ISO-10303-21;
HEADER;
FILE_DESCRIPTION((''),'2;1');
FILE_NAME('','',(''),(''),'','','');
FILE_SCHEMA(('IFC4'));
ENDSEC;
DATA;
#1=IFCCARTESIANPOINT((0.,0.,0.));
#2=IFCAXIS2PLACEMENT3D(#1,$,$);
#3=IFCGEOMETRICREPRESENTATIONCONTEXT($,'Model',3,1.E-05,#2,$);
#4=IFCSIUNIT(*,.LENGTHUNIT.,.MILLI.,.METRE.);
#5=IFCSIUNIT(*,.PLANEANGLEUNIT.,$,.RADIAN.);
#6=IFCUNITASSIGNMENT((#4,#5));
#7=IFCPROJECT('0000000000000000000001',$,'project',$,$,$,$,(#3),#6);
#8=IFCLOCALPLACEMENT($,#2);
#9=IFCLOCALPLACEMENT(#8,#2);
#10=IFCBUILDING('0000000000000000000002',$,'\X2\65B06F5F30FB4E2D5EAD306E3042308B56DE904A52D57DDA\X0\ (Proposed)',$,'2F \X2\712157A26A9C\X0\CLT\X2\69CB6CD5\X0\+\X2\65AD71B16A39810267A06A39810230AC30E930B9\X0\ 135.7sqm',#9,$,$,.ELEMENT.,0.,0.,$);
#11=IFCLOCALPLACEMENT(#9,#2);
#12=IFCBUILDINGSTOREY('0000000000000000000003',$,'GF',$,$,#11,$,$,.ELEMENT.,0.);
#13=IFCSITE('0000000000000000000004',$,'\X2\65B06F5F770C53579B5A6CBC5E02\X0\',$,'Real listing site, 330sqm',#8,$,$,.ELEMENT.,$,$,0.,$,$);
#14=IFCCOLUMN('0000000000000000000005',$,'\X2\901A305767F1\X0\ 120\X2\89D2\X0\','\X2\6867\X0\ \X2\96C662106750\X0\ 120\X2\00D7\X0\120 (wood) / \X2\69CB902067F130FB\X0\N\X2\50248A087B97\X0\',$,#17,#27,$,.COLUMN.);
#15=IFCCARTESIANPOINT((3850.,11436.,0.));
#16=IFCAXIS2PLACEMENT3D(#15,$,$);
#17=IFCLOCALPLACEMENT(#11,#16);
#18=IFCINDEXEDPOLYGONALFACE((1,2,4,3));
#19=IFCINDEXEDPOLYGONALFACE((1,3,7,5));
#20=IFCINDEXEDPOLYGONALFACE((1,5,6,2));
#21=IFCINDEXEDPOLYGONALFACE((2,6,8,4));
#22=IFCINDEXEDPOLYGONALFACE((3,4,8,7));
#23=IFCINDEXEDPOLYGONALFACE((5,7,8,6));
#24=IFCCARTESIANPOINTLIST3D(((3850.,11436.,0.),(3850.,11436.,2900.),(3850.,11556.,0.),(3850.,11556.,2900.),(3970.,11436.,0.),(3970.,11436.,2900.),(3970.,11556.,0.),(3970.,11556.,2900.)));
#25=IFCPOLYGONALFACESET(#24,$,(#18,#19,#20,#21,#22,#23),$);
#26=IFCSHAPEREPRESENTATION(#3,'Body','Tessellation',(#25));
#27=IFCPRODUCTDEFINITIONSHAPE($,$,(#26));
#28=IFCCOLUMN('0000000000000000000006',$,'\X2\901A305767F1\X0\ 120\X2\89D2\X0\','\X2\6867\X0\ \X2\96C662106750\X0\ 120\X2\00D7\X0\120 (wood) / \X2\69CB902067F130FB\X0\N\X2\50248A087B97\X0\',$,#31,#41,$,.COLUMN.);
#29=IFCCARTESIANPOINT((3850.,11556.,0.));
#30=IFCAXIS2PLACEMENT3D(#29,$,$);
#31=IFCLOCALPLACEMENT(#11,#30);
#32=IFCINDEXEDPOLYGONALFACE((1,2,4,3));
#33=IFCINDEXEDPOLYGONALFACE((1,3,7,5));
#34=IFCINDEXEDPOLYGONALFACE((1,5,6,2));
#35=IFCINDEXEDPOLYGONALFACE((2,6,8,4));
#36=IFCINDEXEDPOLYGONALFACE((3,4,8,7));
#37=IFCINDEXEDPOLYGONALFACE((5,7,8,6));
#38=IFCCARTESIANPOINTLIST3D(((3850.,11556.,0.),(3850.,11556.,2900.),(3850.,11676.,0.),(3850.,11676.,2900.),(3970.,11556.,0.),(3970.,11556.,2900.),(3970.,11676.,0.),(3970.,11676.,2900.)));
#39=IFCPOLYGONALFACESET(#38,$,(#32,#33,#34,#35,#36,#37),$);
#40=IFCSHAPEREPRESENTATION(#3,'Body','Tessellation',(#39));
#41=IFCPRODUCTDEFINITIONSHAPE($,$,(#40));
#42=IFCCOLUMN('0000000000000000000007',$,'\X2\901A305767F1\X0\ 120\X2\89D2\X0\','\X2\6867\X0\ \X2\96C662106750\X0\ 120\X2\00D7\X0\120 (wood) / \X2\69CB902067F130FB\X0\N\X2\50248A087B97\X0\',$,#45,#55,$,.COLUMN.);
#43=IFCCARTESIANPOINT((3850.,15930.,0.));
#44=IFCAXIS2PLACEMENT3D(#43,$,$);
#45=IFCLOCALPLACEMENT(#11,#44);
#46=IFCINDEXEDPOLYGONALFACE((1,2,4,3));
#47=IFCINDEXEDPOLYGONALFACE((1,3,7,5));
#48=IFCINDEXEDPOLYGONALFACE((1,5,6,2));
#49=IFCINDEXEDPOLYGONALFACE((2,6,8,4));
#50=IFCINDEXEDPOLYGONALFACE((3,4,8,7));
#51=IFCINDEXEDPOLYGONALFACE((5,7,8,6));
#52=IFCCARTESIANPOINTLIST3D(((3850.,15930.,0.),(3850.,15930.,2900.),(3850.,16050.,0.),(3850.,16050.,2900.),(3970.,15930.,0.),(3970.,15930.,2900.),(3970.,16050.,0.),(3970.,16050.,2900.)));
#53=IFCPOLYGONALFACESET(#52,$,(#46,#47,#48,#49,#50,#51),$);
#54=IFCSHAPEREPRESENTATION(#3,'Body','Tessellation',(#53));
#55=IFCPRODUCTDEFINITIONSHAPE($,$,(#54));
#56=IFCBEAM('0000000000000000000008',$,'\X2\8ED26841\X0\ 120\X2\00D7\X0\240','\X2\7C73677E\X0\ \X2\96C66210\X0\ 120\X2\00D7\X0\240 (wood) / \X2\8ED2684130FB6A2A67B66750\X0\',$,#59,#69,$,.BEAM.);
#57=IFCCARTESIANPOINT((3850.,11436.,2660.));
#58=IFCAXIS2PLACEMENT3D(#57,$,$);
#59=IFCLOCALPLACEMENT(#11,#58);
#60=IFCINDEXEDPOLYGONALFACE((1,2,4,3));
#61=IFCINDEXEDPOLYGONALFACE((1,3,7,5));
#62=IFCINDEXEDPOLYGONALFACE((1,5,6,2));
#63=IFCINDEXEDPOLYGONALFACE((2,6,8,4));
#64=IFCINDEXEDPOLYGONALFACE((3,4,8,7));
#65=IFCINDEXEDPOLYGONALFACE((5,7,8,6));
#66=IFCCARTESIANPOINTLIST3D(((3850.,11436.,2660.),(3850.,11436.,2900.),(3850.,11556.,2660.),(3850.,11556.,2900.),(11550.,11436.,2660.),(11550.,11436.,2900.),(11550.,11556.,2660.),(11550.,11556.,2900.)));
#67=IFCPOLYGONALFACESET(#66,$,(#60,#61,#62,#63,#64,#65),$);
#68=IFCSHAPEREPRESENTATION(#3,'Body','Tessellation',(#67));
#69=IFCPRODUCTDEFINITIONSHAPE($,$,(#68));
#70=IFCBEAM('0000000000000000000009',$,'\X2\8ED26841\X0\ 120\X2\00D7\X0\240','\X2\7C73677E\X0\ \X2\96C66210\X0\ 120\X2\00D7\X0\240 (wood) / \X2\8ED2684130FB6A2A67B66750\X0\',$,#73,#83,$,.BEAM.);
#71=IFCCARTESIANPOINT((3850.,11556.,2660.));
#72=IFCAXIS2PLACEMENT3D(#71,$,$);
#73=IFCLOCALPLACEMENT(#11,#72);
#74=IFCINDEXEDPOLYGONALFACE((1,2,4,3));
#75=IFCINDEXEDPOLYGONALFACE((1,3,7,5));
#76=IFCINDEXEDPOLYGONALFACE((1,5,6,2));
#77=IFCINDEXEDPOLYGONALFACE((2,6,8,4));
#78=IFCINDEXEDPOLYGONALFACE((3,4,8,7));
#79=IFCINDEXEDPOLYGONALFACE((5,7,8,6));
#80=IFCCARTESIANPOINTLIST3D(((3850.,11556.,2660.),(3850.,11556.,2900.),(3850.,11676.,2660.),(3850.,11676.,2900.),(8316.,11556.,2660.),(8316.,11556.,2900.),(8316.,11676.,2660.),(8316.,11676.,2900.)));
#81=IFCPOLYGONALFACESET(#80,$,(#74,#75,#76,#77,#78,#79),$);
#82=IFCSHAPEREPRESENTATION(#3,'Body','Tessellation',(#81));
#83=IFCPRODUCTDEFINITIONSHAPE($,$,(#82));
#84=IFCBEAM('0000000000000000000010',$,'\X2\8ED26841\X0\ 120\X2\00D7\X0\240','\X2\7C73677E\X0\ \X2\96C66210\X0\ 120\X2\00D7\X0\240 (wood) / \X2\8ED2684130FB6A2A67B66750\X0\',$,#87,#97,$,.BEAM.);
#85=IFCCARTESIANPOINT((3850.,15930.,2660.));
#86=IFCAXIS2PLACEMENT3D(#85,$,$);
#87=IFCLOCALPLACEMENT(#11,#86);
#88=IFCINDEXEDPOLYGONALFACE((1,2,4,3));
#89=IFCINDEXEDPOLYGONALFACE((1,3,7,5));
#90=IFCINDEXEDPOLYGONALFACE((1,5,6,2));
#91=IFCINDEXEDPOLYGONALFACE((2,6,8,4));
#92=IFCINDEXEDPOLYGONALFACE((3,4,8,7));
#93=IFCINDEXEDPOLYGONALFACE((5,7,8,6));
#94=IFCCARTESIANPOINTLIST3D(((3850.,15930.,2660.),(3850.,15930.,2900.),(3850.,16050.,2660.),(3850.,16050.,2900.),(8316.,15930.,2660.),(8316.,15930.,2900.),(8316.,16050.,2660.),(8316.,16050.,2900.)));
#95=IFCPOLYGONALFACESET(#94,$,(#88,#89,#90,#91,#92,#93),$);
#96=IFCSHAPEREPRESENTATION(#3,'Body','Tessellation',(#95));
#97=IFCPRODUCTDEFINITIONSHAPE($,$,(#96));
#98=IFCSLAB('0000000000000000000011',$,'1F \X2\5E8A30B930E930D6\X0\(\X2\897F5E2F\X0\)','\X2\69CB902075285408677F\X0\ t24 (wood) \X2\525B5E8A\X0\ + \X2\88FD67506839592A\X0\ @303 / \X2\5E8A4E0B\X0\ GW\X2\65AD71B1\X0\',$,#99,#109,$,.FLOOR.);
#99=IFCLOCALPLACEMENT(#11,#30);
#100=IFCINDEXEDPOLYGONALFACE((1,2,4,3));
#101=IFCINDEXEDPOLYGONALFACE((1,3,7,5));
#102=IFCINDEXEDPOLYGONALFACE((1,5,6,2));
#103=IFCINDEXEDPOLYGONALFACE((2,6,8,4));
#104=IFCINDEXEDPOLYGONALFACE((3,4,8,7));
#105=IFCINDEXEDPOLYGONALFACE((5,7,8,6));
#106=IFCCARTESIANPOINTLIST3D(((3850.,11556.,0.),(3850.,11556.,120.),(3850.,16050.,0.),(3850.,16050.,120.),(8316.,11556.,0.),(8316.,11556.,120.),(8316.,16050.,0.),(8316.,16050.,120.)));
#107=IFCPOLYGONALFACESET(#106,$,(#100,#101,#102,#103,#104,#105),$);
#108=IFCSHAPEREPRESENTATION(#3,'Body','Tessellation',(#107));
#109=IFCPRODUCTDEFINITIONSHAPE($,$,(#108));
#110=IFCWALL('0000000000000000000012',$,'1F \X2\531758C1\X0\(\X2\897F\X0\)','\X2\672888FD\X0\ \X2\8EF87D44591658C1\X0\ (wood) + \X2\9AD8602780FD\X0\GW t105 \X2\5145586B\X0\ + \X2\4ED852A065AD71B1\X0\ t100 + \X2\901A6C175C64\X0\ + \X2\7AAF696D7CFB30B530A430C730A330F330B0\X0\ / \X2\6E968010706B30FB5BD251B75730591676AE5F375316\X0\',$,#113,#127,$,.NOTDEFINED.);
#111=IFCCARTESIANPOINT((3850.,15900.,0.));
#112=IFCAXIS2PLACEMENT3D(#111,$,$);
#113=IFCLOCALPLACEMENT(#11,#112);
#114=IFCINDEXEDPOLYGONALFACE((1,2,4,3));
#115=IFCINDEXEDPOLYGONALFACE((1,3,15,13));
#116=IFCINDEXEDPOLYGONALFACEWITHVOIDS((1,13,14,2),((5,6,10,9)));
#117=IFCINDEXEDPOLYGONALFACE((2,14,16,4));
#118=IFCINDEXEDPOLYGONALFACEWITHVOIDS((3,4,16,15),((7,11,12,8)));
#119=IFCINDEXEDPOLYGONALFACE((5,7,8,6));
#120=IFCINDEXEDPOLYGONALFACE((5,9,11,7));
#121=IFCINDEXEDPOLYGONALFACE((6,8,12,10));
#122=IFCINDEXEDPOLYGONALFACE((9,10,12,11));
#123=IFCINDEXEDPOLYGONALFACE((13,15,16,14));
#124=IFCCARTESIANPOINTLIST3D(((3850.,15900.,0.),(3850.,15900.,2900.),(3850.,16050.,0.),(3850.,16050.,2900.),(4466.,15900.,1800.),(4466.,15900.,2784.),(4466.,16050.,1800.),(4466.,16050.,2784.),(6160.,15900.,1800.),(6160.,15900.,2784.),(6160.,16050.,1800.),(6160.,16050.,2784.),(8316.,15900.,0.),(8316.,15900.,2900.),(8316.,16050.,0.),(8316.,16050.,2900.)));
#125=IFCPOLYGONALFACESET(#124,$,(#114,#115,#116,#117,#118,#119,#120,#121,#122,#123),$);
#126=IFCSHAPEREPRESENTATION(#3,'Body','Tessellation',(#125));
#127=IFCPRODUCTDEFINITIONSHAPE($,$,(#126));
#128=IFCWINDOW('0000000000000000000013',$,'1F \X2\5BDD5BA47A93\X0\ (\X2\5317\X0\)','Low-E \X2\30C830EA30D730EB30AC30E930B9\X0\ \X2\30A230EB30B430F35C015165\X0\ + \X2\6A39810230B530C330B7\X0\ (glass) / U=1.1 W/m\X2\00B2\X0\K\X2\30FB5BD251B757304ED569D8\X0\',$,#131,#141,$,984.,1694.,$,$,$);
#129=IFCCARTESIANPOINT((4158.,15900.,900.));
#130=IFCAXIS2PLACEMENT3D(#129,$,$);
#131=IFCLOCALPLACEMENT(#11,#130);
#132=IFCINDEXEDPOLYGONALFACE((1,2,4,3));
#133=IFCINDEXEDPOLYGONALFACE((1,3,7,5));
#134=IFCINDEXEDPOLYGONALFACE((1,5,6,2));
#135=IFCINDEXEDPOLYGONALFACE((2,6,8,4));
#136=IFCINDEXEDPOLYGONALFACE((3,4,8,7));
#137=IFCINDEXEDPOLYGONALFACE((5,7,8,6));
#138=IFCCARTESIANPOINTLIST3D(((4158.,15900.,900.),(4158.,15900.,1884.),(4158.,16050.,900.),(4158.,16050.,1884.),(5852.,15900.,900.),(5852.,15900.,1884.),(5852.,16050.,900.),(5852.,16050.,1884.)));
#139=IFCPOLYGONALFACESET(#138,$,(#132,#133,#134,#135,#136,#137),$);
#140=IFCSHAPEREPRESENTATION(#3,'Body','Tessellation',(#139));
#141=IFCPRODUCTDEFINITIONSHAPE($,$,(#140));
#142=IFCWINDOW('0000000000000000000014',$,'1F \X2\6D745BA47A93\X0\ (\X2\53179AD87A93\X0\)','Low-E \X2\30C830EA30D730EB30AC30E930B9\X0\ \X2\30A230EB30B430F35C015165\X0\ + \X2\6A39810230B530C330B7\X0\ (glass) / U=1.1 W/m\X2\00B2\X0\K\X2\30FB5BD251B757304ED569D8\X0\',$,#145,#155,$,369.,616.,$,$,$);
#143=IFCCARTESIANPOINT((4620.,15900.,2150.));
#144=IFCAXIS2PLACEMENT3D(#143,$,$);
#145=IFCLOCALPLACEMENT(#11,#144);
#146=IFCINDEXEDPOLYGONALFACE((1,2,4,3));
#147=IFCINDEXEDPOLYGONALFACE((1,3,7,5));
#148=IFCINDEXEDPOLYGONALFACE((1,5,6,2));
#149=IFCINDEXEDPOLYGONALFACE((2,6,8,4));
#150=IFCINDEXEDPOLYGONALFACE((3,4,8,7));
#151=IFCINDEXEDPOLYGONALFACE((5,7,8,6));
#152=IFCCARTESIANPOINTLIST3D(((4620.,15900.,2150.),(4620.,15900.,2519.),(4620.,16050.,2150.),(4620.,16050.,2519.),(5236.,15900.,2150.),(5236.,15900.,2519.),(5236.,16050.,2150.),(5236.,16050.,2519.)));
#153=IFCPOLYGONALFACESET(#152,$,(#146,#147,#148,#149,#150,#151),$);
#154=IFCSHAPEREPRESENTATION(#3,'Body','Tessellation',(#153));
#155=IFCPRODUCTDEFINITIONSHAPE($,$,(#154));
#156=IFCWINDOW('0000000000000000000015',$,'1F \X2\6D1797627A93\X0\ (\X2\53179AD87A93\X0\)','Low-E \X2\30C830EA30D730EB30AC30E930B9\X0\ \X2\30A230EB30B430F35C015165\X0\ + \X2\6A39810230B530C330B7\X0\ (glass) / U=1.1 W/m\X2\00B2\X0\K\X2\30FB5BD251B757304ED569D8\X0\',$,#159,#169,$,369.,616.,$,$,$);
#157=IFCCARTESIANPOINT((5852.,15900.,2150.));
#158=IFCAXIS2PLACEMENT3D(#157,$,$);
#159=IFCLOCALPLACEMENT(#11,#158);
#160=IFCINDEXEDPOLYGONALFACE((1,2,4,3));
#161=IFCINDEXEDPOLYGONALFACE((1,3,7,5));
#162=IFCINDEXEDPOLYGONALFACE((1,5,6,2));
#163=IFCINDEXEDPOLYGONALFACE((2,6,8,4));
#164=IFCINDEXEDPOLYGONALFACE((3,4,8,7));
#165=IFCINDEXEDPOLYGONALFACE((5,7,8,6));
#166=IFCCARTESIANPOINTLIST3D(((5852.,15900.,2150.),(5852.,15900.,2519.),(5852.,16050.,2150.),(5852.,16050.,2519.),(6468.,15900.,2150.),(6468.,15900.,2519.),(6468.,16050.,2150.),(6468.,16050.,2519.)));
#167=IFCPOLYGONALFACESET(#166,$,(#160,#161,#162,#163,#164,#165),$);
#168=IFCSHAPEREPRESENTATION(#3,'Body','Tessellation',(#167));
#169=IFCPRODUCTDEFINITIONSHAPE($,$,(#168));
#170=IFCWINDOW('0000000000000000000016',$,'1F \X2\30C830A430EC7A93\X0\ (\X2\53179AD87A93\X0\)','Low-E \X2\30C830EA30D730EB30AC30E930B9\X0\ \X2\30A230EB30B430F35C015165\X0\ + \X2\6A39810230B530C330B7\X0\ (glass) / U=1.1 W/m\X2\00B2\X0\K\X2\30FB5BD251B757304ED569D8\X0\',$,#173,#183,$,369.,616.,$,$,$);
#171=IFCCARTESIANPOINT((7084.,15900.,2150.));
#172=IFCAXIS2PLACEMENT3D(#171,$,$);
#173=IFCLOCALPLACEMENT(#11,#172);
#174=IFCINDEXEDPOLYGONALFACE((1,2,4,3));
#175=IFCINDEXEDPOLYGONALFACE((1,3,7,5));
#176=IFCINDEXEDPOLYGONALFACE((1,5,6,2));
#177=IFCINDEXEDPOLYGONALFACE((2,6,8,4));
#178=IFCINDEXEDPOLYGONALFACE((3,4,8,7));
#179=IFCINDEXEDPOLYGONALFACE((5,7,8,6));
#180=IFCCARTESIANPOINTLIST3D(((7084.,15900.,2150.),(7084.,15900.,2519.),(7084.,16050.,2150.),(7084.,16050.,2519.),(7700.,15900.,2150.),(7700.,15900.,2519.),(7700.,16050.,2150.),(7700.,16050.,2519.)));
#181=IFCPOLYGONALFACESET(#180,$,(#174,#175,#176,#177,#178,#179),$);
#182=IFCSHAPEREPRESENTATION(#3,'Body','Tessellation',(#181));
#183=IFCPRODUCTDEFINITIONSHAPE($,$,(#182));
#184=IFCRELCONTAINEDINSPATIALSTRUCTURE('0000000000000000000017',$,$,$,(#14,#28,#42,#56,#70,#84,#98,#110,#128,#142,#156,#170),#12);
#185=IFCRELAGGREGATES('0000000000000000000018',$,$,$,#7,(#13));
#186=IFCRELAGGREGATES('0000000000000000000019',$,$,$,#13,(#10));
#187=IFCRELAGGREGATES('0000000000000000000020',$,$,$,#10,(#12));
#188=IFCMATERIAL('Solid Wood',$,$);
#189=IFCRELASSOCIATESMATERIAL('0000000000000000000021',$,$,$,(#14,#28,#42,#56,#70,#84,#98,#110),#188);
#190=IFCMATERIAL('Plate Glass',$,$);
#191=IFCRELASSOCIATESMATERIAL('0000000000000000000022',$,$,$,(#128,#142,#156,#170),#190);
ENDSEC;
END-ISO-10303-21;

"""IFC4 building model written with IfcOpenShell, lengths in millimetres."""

from ifc_helpers import new_model, si_unit, frame, frame_2d, origin, place, context, project, spatial, rectangle, extrude, material, element, fill, save


model = new_model("IFC4")

# Units and contexts
model_context = context("Model", 3, precision=1e-05, world=origin())
ifc_project = project(units=[si_unit("LENGTHUNIT", "METRE", prefix="MILLI"), si_unit("PLANEANGLEUNIT", "RADIAN")], contexts=[model_context])

# Site, building, storey
site_placement = place(None, origin())
site = spatial("IfcSite", under=ifc_project, at=site_placement, Name="新潟県南魚沼市", ObjectType="Real listing site, 330sqm", CompositionType="ELEMENT", RefElevation=0.0)
building_placement = place(site_placement, origin())
building = spatial("IfcBuilding", under=site, at=building_placement, Name="新潟・中庭のある回遊動線 (Proposed)", ObjectType="2F 無垢檜CLT構法+断熱樹脂枠樹脂ガラス 135.7sqm", CompositionType="ELEMENT", ElevationOfRefHeight=0.0, ElevationOfTerrain=0.0)
storey_placement = place(building_placement, origin())
storey = spatial("IfcBuildingStorey", under=building, at=storey_placement, Name="GF", CompositionType="ELEMENT", Elevation=0.0)

# Columns
ifc_material_1 = material(Name="Solid Wood")
column_1_placement = place(storey_placement, frame((3850.0, 11436.0, 0.0)))
element("IfcColumn", 1, at=column_1_placement, inside=storey, material=ifc_material_1, Name="通し柱 120角", Description="桧 集成材 120×120 (wood) / 構造柱・N値計算", PredefinedType="COLUMN", context=model_context, shape_type="SweptSolid", body=[
    extrude(rectangle(XDim=120.0, YDim=120.0, at=frame_2d((60.0, 60.0))), frame((3850.0, 11436.0, 0.0)), (0.0, 0.0, 1.0), 2900.0),
])
column_2_placement = place(storey_placement, frame((3850.0, 11556.0, 0.0)))
element("IfcColumn", 2, at=column_2_placement, inside=storey, material=ifc_material_1, Name="通し柱 120角", Description="桧 集成材 120×120 (wood) / 構造柱・N値計算", PredefinedType="COLUMN", context=model_context, shape_type="SweptSolid", body=[
    extrude(rectangle(XDim=120.0, YDim=120.0, at=frame_2d((60.0, 60.0))), frame((3850.0, 11556.0, 0.0)), (0.0, 0.0, 1.0), 2900.0),
])
column_3_placement = place(storey_placement, frame((3850.0, 15930.0, 0.0)))
element("IfcColumn", 3, at=column_3_placement, inside=storey, material=ifc_material_1, Name="通し柱 120角", Description="桧 集成材 120×120 (wood) / 構造柱・N値計算", PredefinedType="COLUMN", context=model_context, shape_type="SweptSolid", body=[
    extrude(rectangle(XDim=120.0, YDim=120.0, at=frame_2d((60.0, 60.0))), frame((3850.0, 15930.0, 0.0)), (0.0, 0.0, 1.0), 2900.0),
])

# Beams
beam_1_placement = place(storey_placement, frame((3850.0, 11436.0, 2660.0)))
element("IfcBeam", 4, at=beam_1_placement, inside=storey, material=ifc_material_1, Name="軒桁 120×240", Description="米松 集成 120×240 (wood) / 軒桁・横架材", PredefinedType="BEAM", context=model_context, shape_type="SweptSolid", body=[
    extrude(rectangle(XDim=7700.0, YDim=120.0, at=frame_2d((3850.0, 60.0))), frame((3850.0, 11436.0, 2660.0)), (0.0, 0.0, 1.0), 240.0),
])
beam_2_placement = place(storey_placement, frame((3850.0, 11556.0, 2660.0)))
element("IfcBeam", 5, at=beam_2_placement, inside=storey, material=ifc_material_1, Name="軒桁 120×240", Description="米松 集成 120×240 (wood) / 軒桁・横架材", PredefinedType="BEAM", context=model_context, shape_type="SweptSolid", body=[
    extrude(rectangle(XDim=4466.0, YDim=120.0, at=frame_2d((2233.0, 60.0))), frame((3850.0, 11556.0, 2660.0)), (0.0, 0.0, 1.0), 240.0),
])
beam_3_placement = place(storey_placement, frame((3850.0, 15930.0, 2660.0)))
element("IfcBeam", 6, at=beam_3_placement, inside=storey, material=ifc_material_1, Name="軒桁 120×240", Description="米松 集成 120×240 (wood) / 軒桁・横架材", PredefinedType="BEAM", context=model_context, shape_type="SweptSolid", body=[
    extrude(rectangle(XDim=4466.0, YDim=120.0, at=frame_2d((2233.0, 60.0))), frame((3850.0, 15930.0, 2660.0)), (0.0, 0.0, 1.0), 240.0),
])

# Slab
slab_placement = place(storey_placement, frame((3850.0, 11556.0, 0.0)))
element("IfcSlab", 7, at=slab_placement, inside=storey, material=ifc_material_1, Name="1F 床スラブ(西帯)", Description="構造用合板 t24 (wood) 剛床 + 製材根太 @303 / 床下 GW断熱", PredefinedType="FLOOR", context=model_context, shape_type="SweptSolid", body=[
    extrude(rectangle(XDim=4466.0, YDim=4494.0, at=frame_2d((2233.0, 2247.0))), frame((3850.0, 11556.0, 0.0)), (0.0, 0.0, 1.0), 120.0),
])

# Wall, openings, windows
wall_1_placement = place(storey_placement, frame((3850.0, 15900.0, 0.0)))
wall_1 = element("IfcWall", 8, at=wall_1_placement, inside=storey, material=ifc_material_1, Name="1F 北壁(西)", Description="木製 軸組外壁 (wood) + 高性能GW t105 充填 + 付加断熱 t100 + 通気層 + 窯業系サイディング / 準耐火・寒冷地外皮強化", PredefinedType="NOTDEFINED", context=model_context, shape_type="SweptSolid", body=[
    extrude(rectangle(XDim=4466.0, YDim=150.0, at=frame_2d((2233.0, 75.0))), frame((3850.0, 15900.0, 0.0)), (0.0, 0.0, 1.0), 2900.0),
])
opening_1_placement = place(storey_placement, frame((4158.0, 15900.0, 900.0)))
opening_1 = element("IfcOpeningElement", 9, at=opening_1_placement, cuts=wall_1, PredefinedType="NOTDEFINED", context=model_context, shape_type="SweptSolid", body=[
    extrude(rectangle(XDim=1694.0, YDim=150.0, at=frame_2d((847.0, 75.0))), frame((4158.0, 15900.0, 900.0)), (0.0, 0.0, 1.0), 984.0),
])
opening_2_placement = place(storey_placement, frame((4620.0, 15900.0, 2150.0)))
opening_2 = element("IfcOpeningElement", 10, at=opening_2_placement, cuts=wall_1, PredefinedType="NOTDEFINED", context=model_context, shape_type="SweptSolid", body=[
    extrude(rectangle(XDim=616.0, YDim=150.0, at=frame_2d((308.0, 75.0))), frame((4620.0, 15900.0, 2150.0)), (0.0, 0.0, 1.0), 369.0),
])
opening_3_placement = place(storey_placement, frame((5852.0, 15900.0, 2150.0)))
opening_3 = element("IfcOpeningElement", 11, at=opening_3_placement, cuts=wall_1, PredefinedType="NOTDEFINED", context=model_context, shape_type="SweptSolid", body=[
    extrude(rectangle(XDim=616.0, YDim=150.0, at=frame_2d((308.0, 75.0))), frame((5852.0, 15900.0, 2150.0)), (0.0, 0.0, 1.0), 369.0),
])
opening_4_placement = place(storey_placement, frame((7084.0, 15900.0, 2150.0)))
opening_4 = element("IfcOpeningElement", 12, at=opening_4_placement, cuts=wall_1, PredefinedType="NOTDEFINED", context=model_context, shape_type="SweptSolid", body=[
    extrude(rectangle(XDim=616.0, YDim=150.0, at=frame_2d((308.0, 75.0))), frame((7084.0, 15900.0, 2150.0)), (0.0, 0.0, 1.0), 369.0),
])
ifc_material_2 = material(Name="Plate Glass")
window_1_placement = place(storey_placement, frame((4158.0, 15900.0, 900.0)))
window_1 = element("IfcWindow", 13, at=window_1_placement, inside=storey, material=ifc_material_2, Name="1F 寝室窓 (北)", Description="Low-E トリプルガラス アルゴン封入 + 樹脂サッシ (glass) / U=1.1 W/m²K・寒冷地仕様", OverallHeight=984.0, OverallWidth=1694.0, context=model_context, shape_type="SweptSolid", body=[
    extrude(rectangle(XDim=1694.0, YDim=150.0, at=frame_2d((847.0, 75.0))), frame((4158.0, 15900.0, 900.0)), (0.0, 0.0, 1.0), 984.0),
])
fill(opening_1, window_1)
window_2_placement = place(storey_placement, frame((4620.0, 15900.0, 2150.0)))
window_2 = element("IfcWindow", 14, at=window_2_placement, inside=storey, material=ifc_material_2, Name="1F 浴室窓 (北高窓)", Description="Low-E トリプルガラス アルゴン封入 + 樹脂サッシ (glass) / U=1.1 W/m²K・寒冷地仕様", OverallHeight=369.0, OverallWidth=616.0, context=model_context, shape_type="SweptSolid", body=[
    extrude(rectangle(XDim=616.0, YDim=150.0, at=frame_2d((308.0, 75.0))), frame((4620.0, 15900.0, 2150.0)), (0.0, 0.0, 1.0), 369.0),
])
fill(opening_2, window_2)
window_3_placement = place(storey_placement, frame((5852.0, 15900.0, 2150.0)))
window_3 = element("IfcWindow", 15, at=window_3_placement, inside=storey, material=ifc_material_2, Name="1F 洗面窓 (北高窓)", Description="Low-E トリプルガラス アルゴン封入 + 樹脂サッシ (glass) / U=1.1 W/m²K・寒冷地仕様", OverallHeight=369.0, OverallWidth=616.0, context=model_context, shape_type="SweptSolid", body=[
    extrude(rectangle(XDim=616.0, YDim=150.0, at=frame_2d((308.0, 75.0))), frame((5852.0, 15900.0, 2150.0)), (0.0, 0.0, 1.0), 369.0),
])
fill(opening_3, window_3)
window_4_placement = place(storey_placement, frame((7084.0, 15900.0, 2150.0)))
window_4 = element("IfcWindow", 16, at=window_4_placement, inside=storey, material=ifc_material_2, Name="1F トイレ窓 (北高窓)", Description="Low-E トリプルガラス アルゴン封入 + 樹脂サッシ (glass) / U=1.1 W/m²K・寒冷地仕様", OverallHeight=369.0, OverallWidth=616.0, context=model_context, shape_type="SweptSolid", body=[
    extrude(rectangle(XDim=616.0, YDim=150.0, at=frame_2d((308.0, 75.0))), frame((7084.0, 15900.0, 2150.0)), (0.0, 0.0, 1.0), 369.0),
])
fill(opening_4, window_4)

save(model, "model.ifc")
